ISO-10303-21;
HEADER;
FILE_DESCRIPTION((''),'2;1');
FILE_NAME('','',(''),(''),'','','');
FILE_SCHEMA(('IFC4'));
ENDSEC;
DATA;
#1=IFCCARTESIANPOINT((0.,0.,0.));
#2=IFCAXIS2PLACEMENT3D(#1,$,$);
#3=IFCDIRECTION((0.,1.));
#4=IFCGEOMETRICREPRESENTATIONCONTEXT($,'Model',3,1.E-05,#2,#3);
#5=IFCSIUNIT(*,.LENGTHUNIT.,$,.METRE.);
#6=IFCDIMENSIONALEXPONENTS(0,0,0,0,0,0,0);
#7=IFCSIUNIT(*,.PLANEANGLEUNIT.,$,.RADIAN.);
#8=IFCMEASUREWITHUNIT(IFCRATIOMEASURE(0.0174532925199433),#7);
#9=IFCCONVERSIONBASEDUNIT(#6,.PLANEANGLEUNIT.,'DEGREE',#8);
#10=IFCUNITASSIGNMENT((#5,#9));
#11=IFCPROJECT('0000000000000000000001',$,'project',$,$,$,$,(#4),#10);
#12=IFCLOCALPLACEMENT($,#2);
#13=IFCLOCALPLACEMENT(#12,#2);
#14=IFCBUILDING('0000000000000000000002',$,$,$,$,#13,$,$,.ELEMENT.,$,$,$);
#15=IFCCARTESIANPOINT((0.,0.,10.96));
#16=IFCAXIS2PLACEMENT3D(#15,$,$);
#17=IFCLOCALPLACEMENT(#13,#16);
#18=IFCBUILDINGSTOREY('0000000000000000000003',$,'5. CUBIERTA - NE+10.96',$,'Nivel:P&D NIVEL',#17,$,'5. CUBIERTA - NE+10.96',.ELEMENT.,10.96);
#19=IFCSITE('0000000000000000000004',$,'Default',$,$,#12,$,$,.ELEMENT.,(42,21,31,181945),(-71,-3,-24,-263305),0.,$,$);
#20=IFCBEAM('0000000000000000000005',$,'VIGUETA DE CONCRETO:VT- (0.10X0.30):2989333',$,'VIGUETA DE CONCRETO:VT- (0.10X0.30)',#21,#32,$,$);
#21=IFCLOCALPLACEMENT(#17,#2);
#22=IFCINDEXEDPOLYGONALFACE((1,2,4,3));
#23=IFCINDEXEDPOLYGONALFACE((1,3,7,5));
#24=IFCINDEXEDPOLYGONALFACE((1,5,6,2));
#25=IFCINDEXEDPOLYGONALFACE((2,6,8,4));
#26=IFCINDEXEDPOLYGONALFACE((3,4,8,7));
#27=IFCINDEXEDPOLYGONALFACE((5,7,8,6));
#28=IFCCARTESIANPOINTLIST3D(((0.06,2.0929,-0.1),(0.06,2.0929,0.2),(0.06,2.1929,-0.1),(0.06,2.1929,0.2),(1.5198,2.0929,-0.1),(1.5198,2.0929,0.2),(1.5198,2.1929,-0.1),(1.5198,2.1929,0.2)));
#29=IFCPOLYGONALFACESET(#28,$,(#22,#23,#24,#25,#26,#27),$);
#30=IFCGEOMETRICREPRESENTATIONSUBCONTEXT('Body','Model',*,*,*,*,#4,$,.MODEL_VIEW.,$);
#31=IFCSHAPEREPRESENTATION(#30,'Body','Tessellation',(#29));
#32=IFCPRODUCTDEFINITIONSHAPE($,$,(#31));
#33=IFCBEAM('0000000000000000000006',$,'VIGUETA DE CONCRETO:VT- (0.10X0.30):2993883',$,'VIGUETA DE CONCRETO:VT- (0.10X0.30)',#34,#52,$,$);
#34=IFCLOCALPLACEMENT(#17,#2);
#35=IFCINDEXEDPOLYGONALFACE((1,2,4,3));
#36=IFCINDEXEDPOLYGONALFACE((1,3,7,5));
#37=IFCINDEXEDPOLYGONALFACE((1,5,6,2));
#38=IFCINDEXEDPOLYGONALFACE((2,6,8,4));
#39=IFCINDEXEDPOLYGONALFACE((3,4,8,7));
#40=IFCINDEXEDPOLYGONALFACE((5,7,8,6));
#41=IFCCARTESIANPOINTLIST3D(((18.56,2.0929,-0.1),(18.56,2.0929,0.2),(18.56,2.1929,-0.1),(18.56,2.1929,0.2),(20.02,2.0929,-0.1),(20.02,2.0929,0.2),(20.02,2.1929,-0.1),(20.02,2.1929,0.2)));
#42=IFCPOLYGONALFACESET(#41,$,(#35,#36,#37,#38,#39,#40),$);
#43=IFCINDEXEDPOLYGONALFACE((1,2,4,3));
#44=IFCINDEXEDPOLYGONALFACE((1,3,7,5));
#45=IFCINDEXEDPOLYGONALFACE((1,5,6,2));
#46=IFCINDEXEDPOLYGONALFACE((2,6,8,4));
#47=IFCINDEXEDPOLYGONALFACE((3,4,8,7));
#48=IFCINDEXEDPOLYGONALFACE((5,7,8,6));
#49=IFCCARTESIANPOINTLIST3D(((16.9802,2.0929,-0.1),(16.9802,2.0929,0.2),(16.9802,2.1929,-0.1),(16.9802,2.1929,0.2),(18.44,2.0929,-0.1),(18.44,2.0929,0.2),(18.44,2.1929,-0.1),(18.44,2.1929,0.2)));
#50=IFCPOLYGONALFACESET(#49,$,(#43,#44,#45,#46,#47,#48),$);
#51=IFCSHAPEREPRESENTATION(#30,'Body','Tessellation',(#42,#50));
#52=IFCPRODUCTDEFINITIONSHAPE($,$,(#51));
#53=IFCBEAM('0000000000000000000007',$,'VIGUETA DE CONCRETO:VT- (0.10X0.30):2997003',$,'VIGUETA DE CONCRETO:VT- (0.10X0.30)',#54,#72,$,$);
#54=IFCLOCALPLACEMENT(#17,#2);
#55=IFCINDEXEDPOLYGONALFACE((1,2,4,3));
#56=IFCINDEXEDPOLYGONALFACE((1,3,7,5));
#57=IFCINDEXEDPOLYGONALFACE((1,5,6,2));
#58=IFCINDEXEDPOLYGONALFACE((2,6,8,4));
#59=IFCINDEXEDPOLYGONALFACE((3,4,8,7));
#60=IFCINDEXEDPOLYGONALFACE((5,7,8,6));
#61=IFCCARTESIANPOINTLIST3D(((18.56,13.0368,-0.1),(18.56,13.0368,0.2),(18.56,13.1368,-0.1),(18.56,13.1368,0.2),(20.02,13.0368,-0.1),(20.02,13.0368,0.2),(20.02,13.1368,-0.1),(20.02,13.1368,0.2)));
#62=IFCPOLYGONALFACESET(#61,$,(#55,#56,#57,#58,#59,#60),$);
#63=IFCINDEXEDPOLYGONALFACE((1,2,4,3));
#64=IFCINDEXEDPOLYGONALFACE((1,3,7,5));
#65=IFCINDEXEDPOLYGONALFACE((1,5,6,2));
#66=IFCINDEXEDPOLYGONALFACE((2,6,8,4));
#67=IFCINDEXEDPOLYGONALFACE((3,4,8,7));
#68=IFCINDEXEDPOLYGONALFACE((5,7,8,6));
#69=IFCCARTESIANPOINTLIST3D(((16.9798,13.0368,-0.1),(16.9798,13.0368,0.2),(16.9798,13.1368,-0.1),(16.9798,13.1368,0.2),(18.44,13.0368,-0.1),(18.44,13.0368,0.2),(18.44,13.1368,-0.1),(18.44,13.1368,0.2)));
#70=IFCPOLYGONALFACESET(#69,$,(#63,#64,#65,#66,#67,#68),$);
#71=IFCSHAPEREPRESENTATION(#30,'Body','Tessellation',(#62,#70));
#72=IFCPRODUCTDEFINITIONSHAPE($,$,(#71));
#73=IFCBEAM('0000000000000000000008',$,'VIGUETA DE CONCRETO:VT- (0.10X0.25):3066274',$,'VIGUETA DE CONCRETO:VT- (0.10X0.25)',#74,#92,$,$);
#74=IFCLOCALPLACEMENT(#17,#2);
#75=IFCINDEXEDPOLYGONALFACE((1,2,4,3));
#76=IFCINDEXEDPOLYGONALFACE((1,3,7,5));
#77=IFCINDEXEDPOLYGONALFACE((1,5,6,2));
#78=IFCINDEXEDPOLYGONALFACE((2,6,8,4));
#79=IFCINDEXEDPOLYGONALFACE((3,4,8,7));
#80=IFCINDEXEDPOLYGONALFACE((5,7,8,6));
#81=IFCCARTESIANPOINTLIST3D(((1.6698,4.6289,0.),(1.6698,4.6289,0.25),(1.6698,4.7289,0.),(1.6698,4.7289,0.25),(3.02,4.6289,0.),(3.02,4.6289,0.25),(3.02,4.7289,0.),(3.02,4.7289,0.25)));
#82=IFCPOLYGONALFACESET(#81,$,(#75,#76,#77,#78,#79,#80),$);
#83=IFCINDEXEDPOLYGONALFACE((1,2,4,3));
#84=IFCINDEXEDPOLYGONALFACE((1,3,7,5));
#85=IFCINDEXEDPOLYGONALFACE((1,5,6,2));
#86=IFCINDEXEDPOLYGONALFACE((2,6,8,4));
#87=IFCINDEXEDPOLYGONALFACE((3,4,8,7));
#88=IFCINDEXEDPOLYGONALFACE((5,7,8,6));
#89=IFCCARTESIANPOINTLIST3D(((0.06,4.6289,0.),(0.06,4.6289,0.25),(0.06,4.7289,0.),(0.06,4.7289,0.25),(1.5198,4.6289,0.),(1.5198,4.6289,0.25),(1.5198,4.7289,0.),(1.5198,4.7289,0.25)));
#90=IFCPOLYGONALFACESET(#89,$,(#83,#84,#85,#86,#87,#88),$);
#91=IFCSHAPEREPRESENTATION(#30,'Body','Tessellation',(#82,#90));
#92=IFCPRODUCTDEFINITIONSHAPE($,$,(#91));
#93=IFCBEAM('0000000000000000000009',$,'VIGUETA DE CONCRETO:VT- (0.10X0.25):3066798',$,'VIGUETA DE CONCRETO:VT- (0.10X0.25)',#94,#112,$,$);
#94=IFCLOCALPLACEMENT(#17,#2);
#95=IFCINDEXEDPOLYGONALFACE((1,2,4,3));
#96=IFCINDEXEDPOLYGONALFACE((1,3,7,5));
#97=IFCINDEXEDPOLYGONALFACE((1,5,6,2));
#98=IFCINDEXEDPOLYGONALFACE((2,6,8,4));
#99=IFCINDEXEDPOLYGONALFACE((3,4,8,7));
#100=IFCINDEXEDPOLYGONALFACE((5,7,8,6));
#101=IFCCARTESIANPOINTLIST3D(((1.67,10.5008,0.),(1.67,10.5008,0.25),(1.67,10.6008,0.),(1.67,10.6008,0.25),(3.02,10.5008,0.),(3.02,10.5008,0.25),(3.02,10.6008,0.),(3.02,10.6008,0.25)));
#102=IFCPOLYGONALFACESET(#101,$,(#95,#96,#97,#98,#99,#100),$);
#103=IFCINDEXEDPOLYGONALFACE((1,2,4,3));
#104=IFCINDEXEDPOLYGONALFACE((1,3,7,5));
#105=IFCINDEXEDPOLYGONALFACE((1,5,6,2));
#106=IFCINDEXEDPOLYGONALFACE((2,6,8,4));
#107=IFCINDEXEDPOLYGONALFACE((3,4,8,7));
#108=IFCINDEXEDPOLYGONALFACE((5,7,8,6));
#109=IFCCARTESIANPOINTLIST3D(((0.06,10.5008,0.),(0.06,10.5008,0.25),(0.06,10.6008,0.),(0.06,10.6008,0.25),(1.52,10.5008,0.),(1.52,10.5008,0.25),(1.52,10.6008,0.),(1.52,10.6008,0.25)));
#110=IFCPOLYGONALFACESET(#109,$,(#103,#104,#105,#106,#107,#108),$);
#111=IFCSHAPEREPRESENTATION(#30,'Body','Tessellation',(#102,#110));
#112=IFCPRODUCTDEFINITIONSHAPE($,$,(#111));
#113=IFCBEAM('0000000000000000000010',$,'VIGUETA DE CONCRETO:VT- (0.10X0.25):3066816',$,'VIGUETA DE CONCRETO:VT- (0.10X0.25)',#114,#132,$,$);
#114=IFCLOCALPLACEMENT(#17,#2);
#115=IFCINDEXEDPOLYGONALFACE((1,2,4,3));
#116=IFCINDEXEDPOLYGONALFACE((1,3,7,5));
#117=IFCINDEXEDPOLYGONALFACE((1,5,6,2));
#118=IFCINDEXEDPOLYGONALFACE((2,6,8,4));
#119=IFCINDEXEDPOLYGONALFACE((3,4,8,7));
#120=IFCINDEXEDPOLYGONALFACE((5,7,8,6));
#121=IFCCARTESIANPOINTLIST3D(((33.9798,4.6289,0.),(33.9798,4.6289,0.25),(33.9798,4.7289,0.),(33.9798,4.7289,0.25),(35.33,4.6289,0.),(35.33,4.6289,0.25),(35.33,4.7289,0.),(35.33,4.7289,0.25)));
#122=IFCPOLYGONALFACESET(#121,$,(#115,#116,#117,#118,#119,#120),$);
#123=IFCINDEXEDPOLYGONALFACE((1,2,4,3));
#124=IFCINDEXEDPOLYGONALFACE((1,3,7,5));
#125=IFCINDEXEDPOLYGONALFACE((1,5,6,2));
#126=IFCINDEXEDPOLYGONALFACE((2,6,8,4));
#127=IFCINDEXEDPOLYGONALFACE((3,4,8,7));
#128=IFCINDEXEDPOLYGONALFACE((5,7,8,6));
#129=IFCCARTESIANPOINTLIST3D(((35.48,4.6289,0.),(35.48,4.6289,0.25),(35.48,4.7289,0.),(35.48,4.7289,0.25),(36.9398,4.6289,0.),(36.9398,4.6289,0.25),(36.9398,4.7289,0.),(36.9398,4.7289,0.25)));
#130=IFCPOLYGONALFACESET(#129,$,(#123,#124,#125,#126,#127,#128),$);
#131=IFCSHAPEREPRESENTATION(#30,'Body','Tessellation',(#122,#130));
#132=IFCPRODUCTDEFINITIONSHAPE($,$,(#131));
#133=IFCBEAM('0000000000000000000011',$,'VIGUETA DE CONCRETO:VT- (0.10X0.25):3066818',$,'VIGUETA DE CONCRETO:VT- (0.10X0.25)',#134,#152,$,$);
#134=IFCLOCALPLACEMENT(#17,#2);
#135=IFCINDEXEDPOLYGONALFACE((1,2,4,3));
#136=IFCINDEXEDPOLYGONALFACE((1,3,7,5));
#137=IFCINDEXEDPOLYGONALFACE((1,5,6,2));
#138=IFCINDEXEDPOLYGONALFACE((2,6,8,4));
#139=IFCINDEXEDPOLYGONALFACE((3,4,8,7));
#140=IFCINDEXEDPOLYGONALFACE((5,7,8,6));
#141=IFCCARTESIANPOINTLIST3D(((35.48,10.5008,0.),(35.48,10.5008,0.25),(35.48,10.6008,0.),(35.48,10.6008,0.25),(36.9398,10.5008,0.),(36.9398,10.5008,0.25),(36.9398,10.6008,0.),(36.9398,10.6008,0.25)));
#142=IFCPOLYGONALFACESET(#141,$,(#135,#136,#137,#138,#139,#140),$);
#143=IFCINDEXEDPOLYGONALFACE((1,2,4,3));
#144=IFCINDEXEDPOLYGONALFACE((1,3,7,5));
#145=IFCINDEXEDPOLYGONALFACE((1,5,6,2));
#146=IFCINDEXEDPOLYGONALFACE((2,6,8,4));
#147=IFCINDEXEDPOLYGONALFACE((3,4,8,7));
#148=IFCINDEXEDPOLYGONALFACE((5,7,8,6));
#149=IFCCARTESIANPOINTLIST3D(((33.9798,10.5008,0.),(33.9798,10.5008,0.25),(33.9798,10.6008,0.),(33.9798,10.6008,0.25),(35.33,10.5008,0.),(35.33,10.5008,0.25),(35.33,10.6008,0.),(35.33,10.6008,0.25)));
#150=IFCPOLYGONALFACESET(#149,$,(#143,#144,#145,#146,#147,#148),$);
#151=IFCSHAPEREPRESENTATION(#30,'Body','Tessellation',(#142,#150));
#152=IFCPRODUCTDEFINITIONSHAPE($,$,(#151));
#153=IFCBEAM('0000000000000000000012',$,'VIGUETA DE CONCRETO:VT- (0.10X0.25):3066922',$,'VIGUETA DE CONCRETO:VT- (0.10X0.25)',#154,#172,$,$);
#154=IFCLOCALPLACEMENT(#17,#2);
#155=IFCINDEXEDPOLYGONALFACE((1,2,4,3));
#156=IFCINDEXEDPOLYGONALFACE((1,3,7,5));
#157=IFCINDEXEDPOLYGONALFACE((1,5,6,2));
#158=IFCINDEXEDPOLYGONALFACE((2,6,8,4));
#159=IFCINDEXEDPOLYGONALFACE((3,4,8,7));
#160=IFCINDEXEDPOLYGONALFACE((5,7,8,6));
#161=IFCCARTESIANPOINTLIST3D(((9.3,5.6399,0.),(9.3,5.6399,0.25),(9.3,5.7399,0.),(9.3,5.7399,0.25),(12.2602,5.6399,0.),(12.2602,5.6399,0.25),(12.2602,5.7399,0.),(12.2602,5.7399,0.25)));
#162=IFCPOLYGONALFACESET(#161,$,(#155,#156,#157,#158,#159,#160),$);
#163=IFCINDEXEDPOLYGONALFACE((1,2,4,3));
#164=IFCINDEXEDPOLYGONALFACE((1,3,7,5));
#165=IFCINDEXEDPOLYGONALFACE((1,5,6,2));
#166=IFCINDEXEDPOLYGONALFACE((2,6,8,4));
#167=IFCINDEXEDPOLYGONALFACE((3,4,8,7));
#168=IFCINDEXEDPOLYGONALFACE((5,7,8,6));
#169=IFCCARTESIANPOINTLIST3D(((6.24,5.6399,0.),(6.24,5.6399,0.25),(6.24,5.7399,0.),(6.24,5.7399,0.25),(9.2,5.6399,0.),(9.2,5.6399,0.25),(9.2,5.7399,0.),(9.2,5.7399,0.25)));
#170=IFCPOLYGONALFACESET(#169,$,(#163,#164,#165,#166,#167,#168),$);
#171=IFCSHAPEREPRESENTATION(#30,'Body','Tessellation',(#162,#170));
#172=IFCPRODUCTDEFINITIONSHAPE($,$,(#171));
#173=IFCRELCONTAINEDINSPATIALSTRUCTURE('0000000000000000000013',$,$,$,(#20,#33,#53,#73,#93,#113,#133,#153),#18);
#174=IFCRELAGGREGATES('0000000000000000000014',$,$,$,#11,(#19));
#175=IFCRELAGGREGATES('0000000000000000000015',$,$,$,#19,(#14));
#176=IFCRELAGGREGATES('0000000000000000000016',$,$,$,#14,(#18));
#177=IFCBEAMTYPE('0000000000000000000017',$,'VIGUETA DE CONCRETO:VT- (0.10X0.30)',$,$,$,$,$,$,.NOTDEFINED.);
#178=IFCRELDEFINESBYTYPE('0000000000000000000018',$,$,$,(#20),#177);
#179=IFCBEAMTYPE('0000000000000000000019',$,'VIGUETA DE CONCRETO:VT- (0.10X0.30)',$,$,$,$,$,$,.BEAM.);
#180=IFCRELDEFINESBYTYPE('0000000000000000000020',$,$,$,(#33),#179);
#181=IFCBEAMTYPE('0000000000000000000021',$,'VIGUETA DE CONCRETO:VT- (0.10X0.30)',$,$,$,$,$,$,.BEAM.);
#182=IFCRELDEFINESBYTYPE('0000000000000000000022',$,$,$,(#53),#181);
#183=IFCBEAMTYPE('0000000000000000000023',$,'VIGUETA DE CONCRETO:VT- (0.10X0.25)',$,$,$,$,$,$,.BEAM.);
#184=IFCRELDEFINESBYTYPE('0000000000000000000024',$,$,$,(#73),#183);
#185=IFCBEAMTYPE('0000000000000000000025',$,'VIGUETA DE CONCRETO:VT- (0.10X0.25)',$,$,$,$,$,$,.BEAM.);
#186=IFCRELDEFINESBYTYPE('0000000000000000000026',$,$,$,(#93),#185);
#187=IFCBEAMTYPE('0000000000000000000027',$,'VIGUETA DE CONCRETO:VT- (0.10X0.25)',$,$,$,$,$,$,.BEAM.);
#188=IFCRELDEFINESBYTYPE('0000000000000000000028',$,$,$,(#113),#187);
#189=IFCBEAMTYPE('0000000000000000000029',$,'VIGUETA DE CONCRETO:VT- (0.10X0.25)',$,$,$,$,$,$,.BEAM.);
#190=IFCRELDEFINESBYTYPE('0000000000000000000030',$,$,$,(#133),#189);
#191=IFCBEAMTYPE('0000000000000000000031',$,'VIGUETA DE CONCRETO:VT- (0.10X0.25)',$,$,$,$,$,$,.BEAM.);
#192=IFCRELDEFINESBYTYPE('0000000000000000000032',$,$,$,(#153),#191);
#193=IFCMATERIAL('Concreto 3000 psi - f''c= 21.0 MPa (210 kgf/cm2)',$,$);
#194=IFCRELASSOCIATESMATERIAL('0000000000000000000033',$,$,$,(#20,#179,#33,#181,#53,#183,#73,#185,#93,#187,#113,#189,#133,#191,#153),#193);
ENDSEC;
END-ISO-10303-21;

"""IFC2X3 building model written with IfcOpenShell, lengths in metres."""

from ifc_helpers import new_model, entity, si_unit, converted_unit, direction, frame, frame_2d, origin, place, context, subcontext, project, spatial, rectangle, extrude, source, transform, mapped, material, type_object, type_shapes, element, save


model = new_model("IFC2X3")

# Units and contexts
model_context = context("Model", 3, precision=1e-05, world=origin(), true_north=direction((0.0, 1.0)))
body_context = subcontext(model_context, "Body", "Model", "MODEL_VIEW")
ifc_project = project(units=[si_unit("LENGTHUNIT", "METRE"), converted_unit("PLANEANGLEUNIT", "DEGREE", entity("IfcRatioMeasure", 0.0174532925199433), si_unit("PLANEANGLEUNIT", "RADIAN"), dimensions=[0, 0, 0, 0, 0, 0, 0])], contexts=[model_context])

# Site, building, storey
site_placement = place(None, origin())
site = spatial("IfcSite", under=ifc_project, at=site_placement, Name="Default", CompositionType="ELEMENT", RefLatitude=(42, 21, 31, 181945), RefLongitude=(-71, -3, -24, -263305), RefElevation=0.0)
building_placement = place(site_placement, origin())
building = spatial("IfcBuilding", under=site, at=building_placement, CompositionType="ELEMENT")
storey_placement = place(building_placement, frame((0.0, 0.0, 10.96)))
storey = spatial("IfcBuildingStorey", under=building, at=storey_placement, Name="5. CUBIERTA - NE+10.96", ObjectType="Nivel:P&D NIVEL", LongName="5. CUBIERTA - NE+10.96", CompositionType="ELEMENT", Elevation=10.96)

# Beams
ifc_material_1 = material(Name="Concreto 3000 psi - f'c= 21.0 MPa (210 kgf/cm2)")
beam_type_1 = type_object("IfcBeamType", Name="VIGUETA DE CONCRETO:VT- (0.10X0.30)", PredefinedType="NOTDEFINED")
beam_1_placement = place(storey_placement, frame((0.0, 2.1429, 0.0)))
element("IfcBeam", 1, at=beam_1_placement, inside=storey, type_object=beam_type_1, material=ifc_material_1, Name="VIGUETA DE CONCRETO:VT- (0.10X0.30):2989333", ObjectType="VIGUETA DE CONCRETO:VT- (0.10X0.30)", context=body_context, shape_type="SweptSolid", body=[
    extrude(rectangle(XDim=0.3, YDim=0.1, at=frame_2d((0.0, 0.0), x_axis=(1.0, 0.0))), frame((0.06, 0.0, 0.05), z_axis=(1.0, 0.0, 0.0), x_axis=(0.0, 0.0, -1.0)), (0.0, 0.0, 1.0), 1.4598),
])
beam_type_2 = type_object("IfcBeamType", Name="VIGUETA DE CONCRETO:VT- (0.10X0.30)", PredefinedType="BEAM", material=ifc_material_1)
shared_shape_1 = source(origin(), body_context, "Body", "SweptSolid", [
    extrude(rectangle(XDim=0.3, YDim=0.1, at=frame_2d((0.0, 0.0), x_axis=(1.0, 0.0))), frame((18.56, 2.1429, 11.01), z_axis=(1.0, 0.0, 0.0), x_axis=(0.0, 0.0, -1.0)), (0.0, 0.0, 1.0), 1.46),
    extrude(rectangle(XDim=0.3, YDim=0.1, at=frame_2d((0.0, 0.0), x_axis=(1.0, 0.0))), frame((16.9802, 2.1429, 11.01), z_axis=(1.0, 0.0, 0.0), x_axis=(0.0, 0.0, -1.0)), (0.0, 0.0, 1.0), 1.4598),
])
type_shapes(beam_type_2, [shared_shape_1])
beam_2_placement = place(storey_placement, frame((0.0, 0.0, -10.96)))
element("IfcBeam", 2, at=beam_2_placement, inside=storey, type_object=beam_type_2, material=ifc_material_1, Name="VIGUETA DE CONCRETO:VT- (0.10X0.30):2993883", ObjectType="VIGUETA DE CONCRETO:VT- (0.10X0.30)", context=body_context, shape_type="MappedRepresentation", body=[
    mapped(shared_shape_1, transform((0.0, 0.0, 0.0), scale=1.0)),
])
beam_type_3 = type_object("IfcBeamType", Name="VIGUETA DE CONCRETO:VT- (0.10X0.30)", PredefinedType="BEAM", material=ifc_material_1)
shared_shape_2 = source(origin(), body_context, "Body", "SweptSolid", [
    extrude(rectangle(XDim=0.3, YDim=0.1, at=frame_2d((0.0, 0.0), x_axis=(1.0, 0.0))), frame((18.56, 13.0868, 11.01), z_axis=(1.0, 0.0, 0.0), x_axis=(0.0, 0.0, -1.0)), (0.0, 0.0, 1.0), 1.46),
    extrude(rectangle(XDim=0.3, YDim=0.1, at=frame_2d((0.0, 0.0), x_axis=(1.0, 0.0))), frame((16.9798, 13.0868, 11.01), z_axis=(1.0, 0.0, 0.0), x_axis=(0.0, 0.0, -1.0)), (0.0, 0.0, 1.0), 1.4602),
])
type_shapes(beam_type_3, [shared_shape_2])
beam_3_placement = place(storey_placement, frame((0.0, 0.0, -10.96)))
element("IfcBeam", 3, at=beam_3_placement, inside=storey, type_object=beam_type_3, material=ifc_material_1, Name="VIGUETA DE CONCRETO:VT- (0.10X0.30):2997003", ObjectType="VIGUETA DE CONCRETO:VT- (0.10X0.30)", context=body_context, shape_type="MappedRepresentation", body=[
    mapped(shared_shape_2, transform((0.0, 0.0, 0.0), scale=1.0)),
])
beam_type_4 = type_object("IfcBeamType", Name="VIGUETA DE CONCRETO:VT- (0.10X0.25)", PredefinedType="BEAM", material=ifc_material_1)
shared_shape_3 = source(origin(), body_context, "Body", "SweptSolid", [
    extrude(rectangle(XDim=0.25, YDim=0.1, at=frame_2d((0.0, 0.0), x_axis=(1.0, 0.0))), frame((1.6698, 4.6789, 11.085), z_axis=(1.0, 0.0, 0.0), x_axis=(0.0, 0.0, -1.0)), (0.0, 0.0, 1.0), 1.3502),
    extrude(rectangle(XDim=0.25, YDim=0.1, at=frame_2d((0.0, 0.0), x_axis=(1.0, 0.0))), frame((0.06, 4.6789, 11.085), z_axis=(1.0, 0.0, 0.0), x_axis=(0.0, 0.0, -1.0)), (0.0, 0.0, 1.0), 1.4598),
])
type_shapes(beam_type_4, [shared_shape_3])
beam_4_placement = place(storey_placement, frame((0.0, 0.0, -10.96)))
element("IfcBeam", 4, at=beam_4_placement, inside=storey, type_object=beam_type_4, material=ifc_material_1, Name="VIGUETA DE CONCRETO:VT- (0.10X0.25):3066274", ObjectType="VIGUETA DE CONCRETO:VT- (0.10X0.25)", context=body_context, shape_type="MappedRepresentation", body=[
    mapped(shared_shape_3, transform((0.0, 0.0, 0.0), scale=1.0)),
])
beam_type_5 = type_object("IfcBeamType", Name="VIGUETA DE CONCRETO:VT- (0.10X0.25)", PredefinedType="BEAM", material=ifc_material_1)
shared_shape_4 = source(origin(), body_context, "Body", "SweptSolid", [
    extrude(rectangle(XDim=0.25, YDim=0.1, at=frame_2d((0.0, 0.0), x_axis=(1.0, 0.0))), frame((1.67, 10.5508, 11.085), z_axis=(1.0, 0.0, 0.0), x_axis=(0.0, 0.0, -1.0)), (0.0, 0.0, 1.0), 1.35),
    extrude(rectangle(XDim=0.25, YDim=0.1, at=frame_2d((0.0, 0.0), x_axis=(1.0, 0.0))), frame((0.06, 10.5508, 11.085), z_axis=(1.0, 0.0, 0.0), x_axis=(0.0, 0.0, -1.0)), (0.0, 0.0, 1.0), 1.46),
])
type_shapes(beam_type_5, [shared_shape_4])
beam_5_placement = place(storey_placement, frame((0.0, 0.0, -10.96)))
element("IfcBeam", 5, at=beam_5_placement, inside=storey, type_object=beam_type_5, material=ifc_material_1, Name="VIGUETA DE CONCRETO:VT- (0.10X0.25):3066798", ObjectType="VIGUETA DE CONCRETO:VT- (0.10X0.25)", context=body_context, shape_type="MappedRepresentation", body=[
    mapped(shared_shape_4, transform((0.0, 0.0, 0.0), scale=1.0)),
])
beam_type_6 = type_object("IfcBeamType", Name="VIGUETA DE CONCRETO:VT- (0.10X0.25)", PredefinedType="BEAM", material=ifc_material_1)
shared_shape_5 = source(origin(), body_context, "Body", "SweptSolid", [
    extrude(rectangle(XDim=0.25, YDim=0.1, at=frame_2d((0.0, 0.0), x_axis=(1.0, 0.0))), frame((35.33, 4.6789, 11.085), z_axis=(-1.0, 0.0, 0.0), x_axis=(0.0, 0.0, -1.0)), (0.0, 0.0, 1.0), 1.3502),
    extrude(rectangle(XDim=0.25, YDim=0.1, at=frame_2d((0.0, 0.0), x_axis=(1.0, 0.0))), frame((36.9398, 4.6789, 11.085), z_axis=(-1.0, 0.0, 0.0), x_axis=(0.0, 0.0, -1.0)), (0.0, 0.0, 1.0), 1.4598),
])
type_shapes(beam_type_6, [shared_shape_5])
beam_6_placement = place(storey_placement, frame((0.0, 0.0, -10.96)))
element("IfcBeam", 6, at=beam_6_placement, inside=storey, type_object=beam_type_6, material=ifc_material_1, Name="VIGUETA DE CONCRETO:VT- (0.10X0.25):3066816", ObjectType="VIGUETA DE CONCRETO:VT- (0.10X0.25)", context=body_context, shape_type="MappedRepresentation", body=[
    mapped(shared_shape_5, transform((0.0, 0.0, 0.0), scale=1.0)),
])
beam_type_7 = type_object("IfcBeamType", Name="VIGUETA DE CONCRETO:VT- (0.10X0.25)", PredefinedType="BEAM", material=ifc_material_1)
shared_shape_6 = source(origin(), body_context, "Body", "SweptSolid", [
    extrude(rectangle(XDim=0.25, YDim=0.1, at=frame_2d((0.0, 0.0), x_axis=(1.0, 0.0))), frame((36.9398, 10.5508, 11.085), z_axis=(-1.0, 0.0, 0.0), x_axis=(0.0, 0.0, -1.0)), (0.0, 0.0, 1.0), 1.4598),
    extrude(rectangle(XDim=0.25, YDim=0.1, at=frame_2d((0.0, 0.0), x_axis=(1.0, 0.0))), frame((35.33, 10.5508, 11.085), z_axis=(-1.0, 0.0, 0.0), x_axis=(0.0, 0.0, -1.0)), (0.0, 0.0, 1.0), 1.3502),
])
type_shapes(beam_type_7, [shared_shape_6])
beam_7_placement = place(storey_placement, frame((0.0, 0.0, -10.96)))
element("IfcBeam", 7, at=beam_7_placement, inside=storey, type_object=beam_type_7, material=ifc_material_1, Name="VIGUETA DE CONCRETO:VT- (0.10X0.25):3066818", ObjectType="VIGUETA DE CONCRETO:VT- (0.10X0.25)", context=body_context, shape_type="MappedRepresentation", body=[
    mapped(shared_shape_6, transform((0.0, 0.0, 0.0), scale=1.0)),
])
beam_type_8 = type_object("IfcBeamType", Name="VIGUETA DE CONCRETO:VT- (0.10X0.25)", PredefinedType="BEAM", material=ifc_material_1)
shared_shape_7 = source(origin(), body_context, "Body", "SweptSolid", [
    extrude(rectangle(XDim=0.25, YDim=0.1, at=frame_2d((0.0, 0.0), x_axis=(1.0, 0.0))), frame((9.3, 5.6899, 11.085), z_axis=(1.0, 0.0, 0.0), x_axis=(0.0, 0.0, -1.0)), (0.0, 0.0, 1.0), 2.9602),
    extrude(rectangle(XDim=0.25, YDim=0.1, at=frame_2d((0.0, 0.0), x_axis=(1.0, 0.0))), frame((6.24, 5.6899, 11.085), z_axis=(1.0, 0.0, 0.0), x_axis=(0.0, 0.0, -1.0)), (0.0, 0.0, 1.0), 2.96),
])
type_shapes(beam_type_8, [shared_shape_7])
beam_8_placement = place(storey_placement, frame((0.0, 0.0, -10.96)))
element("IfcBeam", 8, at=beam_8_placement, inside=storey, type_object=beam_type_8, material=ifc_material_1, Name="VIGUETA DE CONCRETO:VT- (0.10X0.25):3066922", ObjectType="VIGUETA DE CONCRETO:VT- (0.10X0.25)", context=body_context, shape_type="MappedRepresentation", body=[
    mapped(shared_shape_7, transform((0.0, 0.0, 0.0), scale=1.0)),
])

save(model, "model.ifc")
